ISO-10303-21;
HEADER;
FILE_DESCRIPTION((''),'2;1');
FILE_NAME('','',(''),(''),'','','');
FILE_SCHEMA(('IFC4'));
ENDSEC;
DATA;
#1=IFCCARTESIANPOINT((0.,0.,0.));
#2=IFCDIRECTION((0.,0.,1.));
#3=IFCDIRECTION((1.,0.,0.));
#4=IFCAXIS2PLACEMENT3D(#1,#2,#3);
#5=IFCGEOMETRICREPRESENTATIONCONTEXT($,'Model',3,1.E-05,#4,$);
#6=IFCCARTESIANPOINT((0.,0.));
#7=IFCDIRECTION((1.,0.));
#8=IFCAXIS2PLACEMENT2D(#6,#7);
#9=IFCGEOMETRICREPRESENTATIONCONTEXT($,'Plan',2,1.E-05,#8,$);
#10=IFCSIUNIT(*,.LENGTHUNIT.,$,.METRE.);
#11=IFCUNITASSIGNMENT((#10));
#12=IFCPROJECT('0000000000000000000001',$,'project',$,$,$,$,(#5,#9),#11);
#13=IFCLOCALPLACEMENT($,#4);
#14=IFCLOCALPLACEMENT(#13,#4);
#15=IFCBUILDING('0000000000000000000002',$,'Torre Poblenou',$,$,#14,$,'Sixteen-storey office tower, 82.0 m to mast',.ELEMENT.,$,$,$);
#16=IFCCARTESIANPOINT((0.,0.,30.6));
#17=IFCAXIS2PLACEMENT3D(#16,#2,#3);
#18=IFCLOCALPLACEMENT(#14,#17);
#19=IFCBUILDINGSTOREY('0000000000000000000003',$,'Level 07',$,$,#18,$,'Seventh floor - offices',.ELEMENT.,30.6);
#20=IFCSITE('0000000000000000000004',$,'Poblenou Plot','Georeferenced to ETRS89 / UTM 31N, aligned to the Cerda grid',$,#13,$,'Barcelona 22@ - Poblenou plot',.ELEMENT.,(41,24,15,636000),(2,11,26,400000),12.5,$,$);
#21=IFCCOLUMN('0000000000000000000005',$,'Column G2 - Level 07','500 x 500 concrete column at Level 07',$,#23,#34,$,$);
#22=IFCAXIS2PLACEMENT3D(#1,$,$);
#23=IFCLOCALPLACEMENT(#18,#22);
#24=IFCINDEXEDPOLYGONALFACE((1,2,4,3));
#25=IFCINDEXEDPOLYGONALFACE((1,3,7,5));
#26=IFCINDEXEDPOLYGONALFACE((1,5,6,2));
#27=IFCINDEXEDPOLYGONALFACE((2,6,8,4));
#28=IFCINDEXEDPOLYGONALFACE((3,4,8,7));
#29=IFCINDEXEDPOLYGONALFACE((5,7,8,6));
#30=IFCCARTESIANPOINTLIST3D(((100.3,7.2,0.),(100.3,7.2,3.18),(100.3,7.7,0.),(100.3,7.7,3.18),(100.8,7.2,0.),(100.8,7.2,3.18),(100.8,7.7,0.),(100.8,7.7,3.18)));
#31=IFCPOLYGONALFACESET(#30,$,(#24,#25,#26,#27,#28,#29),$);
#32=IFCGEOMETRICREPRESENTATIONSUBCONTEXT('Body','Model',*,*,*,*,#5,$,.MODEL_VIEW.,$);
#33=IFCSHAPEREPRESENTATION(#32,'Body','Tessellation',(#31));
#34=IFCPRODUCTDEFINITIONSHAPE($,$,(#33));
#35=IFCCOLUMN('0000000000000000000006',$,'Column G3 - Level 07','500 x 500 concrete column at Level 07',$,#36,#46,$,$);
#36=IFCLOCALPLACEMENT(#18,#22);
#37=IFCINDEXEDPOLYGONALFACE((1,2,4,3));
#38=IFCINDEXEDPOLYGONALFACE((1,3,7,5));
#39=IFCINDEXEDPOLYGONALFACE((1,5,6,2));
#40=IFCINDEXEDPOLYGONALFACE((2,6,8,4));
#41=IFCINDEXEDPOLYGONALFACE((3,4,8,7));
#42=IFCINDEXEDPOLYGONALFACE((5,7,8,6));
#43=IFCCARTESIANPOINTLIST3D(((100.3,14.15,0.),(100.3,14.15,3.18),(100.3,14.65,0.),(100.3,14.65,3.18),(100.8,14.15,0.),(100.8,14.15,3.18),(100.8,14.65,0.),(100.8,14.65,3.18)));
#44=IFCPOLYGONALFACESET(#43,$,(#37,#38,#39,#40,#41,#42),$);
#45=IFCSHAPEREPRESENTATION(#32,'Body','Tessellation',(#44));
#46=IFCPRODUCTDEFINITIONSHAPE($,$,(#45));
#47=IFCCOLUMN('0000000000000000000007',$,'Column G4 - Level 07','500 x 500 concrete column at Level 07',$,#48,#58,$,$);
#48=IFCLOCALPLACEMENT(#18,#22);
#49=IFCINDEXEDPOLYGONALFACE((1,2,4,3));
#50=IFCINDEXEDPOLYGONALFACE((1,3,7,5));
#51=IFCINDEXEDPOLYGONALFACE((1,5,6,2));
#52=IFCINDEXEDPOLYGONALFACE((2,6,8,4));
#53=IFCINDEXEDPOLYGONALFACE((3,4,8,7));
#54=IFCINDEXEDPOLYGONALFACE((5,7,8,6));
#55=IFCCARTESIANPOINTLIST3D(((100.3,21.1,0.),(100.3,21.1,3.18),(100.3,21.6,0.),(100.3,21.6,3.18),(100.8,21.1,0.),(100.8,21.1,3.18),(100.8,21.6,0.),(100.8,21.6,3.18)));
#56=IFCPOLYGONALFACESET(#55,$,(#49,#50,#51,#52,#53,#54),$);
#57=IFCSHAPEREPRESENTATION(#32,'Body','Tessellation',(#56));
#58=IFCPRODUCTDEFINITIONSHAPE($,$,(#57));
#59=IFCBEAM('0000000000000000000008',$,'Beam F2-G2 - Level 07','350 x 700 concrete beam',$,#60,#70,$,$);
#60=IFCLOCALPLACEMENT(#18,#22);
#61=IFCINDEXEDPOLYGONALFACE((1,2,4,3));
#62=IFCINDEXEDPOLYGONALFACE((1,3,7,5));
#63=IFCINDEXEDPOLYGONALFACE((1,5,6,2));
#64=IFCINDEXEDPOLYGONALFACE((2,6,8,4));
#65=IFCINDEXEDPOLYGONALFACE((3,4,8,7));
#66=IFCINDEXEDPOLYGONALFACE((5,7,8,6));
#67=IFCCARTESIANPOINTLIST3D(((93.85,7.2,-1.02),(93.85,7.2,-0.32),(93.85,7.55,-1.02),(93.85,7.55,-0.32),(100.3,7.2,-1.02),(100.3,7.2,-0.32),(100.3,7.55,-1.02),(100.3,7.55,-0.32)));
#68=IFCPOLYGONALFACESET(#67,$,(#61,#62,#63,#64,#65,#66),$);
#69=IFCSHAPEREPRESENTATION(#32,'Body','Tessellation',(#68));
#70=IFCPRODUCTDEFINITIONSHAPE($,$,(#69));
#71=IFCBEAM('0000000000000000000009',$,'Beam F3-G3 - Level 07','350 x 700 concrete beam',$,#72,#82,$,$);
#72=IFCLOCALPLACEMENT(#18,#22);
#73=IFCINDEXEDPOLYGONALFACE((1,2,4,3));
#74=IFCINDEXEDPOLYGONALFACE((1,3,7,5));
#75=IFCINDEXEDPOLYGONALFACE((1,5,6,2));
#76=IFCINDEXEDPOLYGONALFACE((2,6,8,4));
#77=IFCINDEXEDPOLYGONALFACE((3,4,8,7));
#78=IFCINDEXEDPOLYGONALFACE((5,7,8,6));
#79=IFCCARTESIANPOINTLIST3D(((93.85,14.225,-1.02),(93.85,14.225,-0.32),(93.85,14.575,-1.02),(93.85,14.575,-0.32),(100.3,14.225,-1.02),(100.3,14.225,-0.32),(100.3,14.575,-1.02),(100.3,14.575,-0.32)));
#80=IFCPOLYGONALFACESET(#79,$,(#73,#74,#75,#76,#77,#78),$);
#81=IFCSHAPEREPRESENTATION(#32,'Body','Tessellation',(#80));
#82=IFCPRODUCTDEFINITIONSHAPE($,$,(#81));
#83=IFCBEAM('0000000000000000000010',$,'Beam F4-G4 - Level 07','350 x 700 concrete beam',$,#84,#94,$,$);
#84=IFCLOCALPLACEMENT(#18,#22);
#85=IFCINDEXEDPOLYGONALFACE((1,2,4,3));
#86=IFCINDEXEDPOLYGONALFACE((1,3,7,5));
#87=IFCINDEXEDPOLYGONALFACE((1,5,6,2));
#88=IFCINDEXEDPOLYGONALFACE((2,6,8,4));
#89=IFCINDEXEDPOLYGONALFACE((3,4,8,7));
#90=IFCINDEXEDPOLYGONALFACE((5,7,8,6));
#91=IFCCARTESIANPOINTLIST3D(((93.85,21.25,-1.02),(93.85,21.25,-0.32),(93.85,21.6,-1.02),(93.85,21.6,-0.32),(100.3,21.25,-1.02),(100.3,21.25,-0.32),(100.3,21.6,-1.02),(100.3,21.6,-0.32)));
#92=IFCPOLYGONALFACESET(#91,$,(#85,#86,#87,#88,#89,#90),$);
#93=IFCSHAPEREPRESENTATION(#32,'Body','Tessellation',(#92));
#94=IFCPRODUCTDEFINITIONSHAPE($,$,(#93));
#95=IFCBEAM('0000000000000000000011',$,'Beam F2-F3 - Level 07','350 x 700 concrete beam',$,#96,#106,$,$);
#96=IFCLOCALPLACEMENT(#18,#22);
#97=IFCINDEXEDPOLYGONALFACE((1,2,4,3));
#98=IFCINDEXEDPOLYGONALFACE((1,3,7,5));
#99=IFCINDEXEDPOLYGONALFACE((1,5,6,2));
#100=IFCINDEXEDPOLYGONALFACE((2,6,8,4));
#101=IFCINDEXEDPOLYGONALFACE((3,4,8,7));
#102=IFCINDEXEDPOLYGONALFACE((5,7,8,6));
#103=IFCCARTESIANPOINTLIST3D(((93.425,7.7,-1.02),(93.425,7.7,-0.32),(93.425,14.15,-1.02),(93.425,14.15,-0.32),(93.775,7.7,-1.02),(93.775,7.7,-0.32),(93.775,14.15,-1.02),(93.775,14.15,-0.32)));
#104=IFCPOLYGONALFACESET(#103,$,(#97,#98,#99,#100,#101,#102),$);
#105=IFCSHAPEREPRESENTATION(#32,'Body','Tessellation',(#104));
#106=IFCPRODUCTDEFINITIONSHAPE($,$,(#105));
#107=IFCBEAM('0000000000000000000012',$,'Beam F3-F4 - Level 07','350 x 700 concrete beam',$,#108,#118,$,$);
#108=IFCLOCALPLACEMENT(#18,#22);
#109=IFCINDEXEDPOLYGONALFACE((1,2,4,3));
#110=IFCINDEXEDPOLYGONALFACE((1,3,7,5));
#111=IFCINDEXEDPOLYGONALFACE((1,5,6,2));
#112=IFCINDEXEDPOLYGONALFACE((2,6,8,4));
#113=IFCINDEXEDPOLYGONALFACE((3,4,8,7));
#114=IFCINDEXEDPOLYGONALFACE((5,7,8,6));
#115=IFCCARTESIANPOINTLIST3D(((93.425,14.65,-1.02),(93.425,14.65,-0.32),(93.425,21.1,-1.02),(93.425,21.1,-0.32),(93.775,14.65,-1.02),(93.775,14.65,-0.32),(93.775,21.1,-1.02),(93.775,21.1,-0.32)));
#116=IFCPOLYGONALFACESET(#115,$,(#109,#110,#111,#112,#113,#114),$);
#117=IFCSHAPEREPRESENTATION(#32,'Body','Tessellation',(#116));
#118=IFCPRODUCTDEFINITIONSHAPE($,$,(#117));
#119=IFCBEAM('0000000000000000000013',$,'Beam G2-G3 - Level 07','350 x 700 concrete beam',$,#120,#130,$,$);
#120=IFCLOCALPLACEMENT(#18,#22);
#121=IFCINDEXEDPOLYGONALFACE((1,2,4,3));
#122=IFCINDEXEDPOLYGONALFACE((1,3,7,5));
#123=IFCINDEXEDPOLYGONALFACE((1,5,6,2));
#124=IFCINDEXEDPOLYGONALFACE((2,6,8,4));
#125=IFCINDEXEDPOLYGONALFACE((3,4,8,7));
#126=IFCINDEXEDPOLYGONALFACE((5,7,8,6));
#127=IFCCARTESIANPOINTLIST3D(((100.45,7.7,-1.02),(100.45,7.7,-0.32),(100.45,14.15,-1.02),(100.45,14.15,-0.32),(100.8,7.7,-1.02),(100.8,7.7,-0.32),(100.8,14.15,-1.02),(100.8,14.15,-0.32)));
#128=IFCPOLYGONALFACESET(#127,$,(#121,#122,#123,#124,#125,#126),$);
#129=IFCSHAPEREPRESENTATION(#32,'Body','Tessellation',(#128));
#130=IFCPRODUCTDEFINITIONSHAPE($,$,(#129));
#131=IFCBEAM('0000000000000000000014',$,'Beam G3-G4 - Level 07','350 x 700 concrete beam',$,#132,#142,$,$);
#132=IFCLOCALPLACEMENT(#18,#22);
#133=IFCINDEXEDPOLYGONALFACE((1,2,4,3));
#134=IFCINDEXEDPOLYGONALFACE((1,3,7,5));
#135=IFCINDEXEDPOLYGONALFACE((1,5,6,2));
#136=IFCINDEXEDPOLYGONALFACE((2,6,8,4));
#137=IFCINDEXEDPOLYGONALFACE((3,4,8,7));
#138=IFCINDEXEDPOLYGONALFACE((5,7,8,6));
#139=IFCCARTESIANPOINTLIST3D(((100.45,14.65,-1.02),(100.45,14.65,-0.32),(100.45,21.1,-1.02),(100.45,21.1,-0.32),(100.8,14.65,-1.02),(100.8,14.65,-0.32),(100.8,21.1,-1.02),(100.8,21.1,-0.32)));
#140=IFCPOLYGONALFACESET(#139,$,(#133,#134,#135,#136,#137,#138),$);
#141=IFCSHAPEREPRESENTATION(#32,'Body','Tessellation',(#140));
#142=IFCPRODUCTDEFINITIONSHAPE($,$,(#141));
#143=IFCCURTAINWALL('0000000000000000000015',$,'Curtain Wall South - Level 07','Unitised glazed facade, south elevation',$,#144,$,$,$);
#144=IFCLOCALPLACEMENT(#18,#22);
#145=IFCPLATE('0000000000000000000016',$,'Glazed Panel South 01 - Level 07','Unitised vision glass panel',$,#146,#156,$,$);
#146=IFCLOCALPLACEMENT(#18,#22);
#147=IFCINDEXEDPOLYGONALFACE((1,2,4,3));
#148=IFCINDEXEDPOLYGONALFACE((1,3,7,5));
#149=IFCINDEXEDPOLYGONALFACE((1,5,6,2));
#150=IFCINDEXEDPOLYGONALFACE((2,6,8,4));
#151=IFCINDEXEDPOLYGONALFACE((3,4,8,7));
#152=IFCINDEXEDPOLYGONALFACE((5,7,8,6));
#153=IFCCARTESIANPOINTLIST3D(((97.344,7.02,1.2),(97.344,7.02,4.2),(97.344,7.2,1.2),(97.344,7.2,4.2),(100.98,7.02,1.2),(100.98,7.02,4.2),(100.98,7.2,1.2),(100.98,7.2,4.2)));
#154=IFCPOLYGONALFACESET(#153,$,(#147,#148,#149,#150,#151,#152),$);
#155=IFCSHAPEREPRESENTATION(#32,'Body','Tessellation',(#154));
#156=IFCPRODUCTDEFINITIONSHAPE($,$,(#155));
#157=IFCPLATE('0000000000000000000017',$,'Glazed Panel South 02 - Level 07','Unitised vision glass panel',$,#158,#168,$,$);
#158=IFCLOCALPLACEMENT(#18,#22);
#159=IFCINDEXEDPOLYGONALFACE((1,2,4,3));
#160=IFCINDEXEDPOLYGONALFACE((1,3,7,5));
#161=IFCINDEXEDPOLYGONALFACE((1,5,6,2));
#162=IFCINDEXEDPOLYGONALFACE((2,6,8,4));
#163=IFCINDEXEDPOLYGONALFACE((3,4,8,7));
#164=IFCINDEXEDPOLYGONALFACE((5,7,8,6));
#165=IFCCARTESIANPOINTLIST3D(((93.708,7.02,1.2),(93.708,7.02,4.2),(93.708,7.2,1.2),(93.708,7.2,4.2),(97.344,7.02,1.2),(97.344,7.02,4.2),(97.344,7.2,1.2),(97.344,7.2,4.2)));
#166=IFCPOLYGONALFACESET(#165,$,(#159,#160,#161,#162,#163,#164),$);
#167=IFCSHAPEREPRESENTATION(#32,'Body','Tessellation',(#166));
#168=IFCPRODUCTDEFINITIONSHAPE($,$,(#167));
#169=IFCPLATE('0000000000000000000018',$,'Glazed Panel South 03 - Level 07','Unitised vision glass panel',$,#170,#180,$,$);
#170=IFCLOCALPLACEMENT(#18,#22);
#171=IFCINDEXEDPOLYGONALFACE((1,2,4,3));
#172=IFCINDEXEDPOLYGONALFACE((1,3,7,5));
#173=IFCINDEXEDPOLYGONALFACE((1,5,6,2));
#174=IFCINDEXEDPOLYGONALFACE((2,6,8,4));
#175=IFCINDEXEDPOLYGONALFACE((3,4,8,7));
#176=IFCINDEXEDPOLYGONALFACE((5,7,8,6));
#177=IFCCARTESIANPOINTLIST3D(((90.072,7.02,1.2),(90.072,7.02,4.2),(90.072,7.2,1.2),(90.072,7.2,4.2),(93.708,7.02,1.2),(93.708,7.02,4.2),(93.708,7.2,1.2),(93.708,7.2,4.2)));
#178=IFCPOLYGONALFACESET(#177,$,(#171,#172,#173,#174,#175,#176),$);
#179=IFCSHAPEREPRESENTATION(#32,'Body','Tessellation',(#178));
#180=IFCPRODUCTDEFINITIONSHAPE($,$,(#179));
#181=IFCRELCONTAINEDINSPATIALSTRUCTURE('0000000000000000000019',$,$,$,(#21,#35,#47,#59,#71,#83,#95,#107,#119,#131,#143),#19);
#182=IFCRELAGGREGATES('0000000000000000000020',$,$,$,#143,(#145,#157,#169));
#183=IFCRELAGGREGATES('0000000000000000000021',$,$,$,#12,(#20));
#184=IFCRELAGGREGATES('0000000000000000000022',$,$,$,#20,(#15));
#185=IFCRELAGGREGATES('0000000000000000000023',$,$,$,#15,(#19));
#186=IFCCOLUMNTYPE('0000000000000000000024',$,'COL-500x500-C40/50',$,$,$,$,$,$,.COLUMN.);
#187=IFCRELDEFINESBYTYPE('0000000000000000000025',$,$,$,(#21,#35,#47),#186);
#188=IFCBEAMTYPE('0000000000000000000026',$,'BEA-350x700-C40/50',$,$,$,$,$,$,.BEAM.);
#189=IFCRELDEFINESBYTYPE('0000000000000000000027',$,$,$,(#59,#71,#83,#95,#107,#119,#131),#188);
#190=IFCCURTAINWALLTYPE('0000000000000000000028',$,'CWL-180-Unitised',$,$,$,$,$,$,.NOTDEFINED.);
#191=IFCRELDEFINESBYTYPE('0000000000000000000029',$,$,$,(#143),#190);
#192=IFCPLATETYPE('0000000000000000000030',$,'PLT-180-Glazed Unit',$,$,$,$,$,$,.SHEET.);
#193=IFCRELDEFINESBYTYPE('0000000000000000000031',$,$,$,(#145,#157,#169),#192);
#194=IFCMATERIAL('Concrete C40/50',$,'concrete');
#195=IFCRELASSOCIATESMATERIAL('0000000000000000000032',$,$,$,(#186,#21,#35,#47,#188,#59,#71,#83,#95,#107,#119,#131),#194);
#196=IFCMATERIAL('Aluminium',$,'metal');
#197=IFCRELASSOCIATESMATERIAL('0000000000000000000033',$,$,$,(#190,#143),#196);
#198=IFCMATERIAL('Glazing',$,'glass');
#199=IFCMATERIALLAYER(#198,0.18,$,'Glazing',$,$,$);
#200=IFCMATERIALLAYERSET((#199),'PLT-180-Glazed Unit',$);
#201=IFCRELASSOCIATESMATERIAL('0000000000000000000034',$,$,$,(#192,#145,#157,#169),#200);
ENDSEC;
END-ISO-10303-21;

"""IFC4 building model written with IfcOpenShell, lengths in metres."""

from ifc_helpers import new_model, si_unit, frame, origin_with_axes, origin_2d_with_axis, place, context, subcontext, project, spatial, line, indexed_curve, rectangle, outline, extrude, material, layer, layer_set, layer_usage, material_profile, profile_set, profile_usage, type_object, element, aggregate, save


model = new_model("IFC4")

# Units and contexts
model_context = context("Model", 3, precision=1e-05, world=origin_with_axes())
plan_context = context("Plan", 2, precision=1e-05, world=origin_2d_with_axis())
body_context = subcontext(model_context, "Body", "Model", "MODEL_VIEW")
ifc_project = project(units=[si_unit("LENGTHUNIT", "METRE")], contexts=[model_context, plan_context])

# Site, building, storey
site_placement = place(None, origin_with_axes())
site = spatial("IfcSite", under=ifc_project, at=site_placement, Name="Poblenou Plot", Description="Georeferenced to ETRS89 / UTM 31N, aligned to the Cerda grid", LongName="Barcelona 22@ - Poblenou plot", CompositionType="ELEMENT", RefLatitude=(41, 24, 15, 636000), RefLongitude=(2, 11, 26, 400000), RefElevation=12.5)
building_placement = place(site_placement, origin_with_axes())
building = spatial("IfcBuilding", under=site, at=building_placement, Name="Torre Poblenou", LongName="Sixteen-storey office tower, 82.0 m to mast", CompositionType="ELEMENT")
storey_placement = place(building_placement, frame((0.0, 0.0, 30.6), z_axis=(0.0, 0.0, 1.0), x_axis=(1.0, 0.0, 0.0)))
storey = spatial("IfcBuildingStorey", under=building, at=storey_placement, Name="Level 07", LongName="Seventh floor - offices", CompositionType="ELEMENT", Elevation=30.6)

# Columns
ifc_material_1 = material(Name="Concrete C40/50", Category="concrete")
ifc_material_profile_1 = material_profile(ifc_material_1, rectangle(XDim=0.5, YDim=0.5))
ifc_profile_set_1 = profile_set([ifc_material_profile_1], Name="COL-500x500-C40/50")
ifc_profile_usage_1 = profile_usage(ifc_profile_set_1)
column_type = type_object("IfcColumnType", Name="COL-500x500-C40/50", PredefinedType="COLUMN", material=ifc_profile_set_1)
column_1_placement = place(storey_placement, frame((100.3, 7.2, 0.0), z_axis=(0.0, 0.0, 1.0), x_axis=(1.0, 0.0, 0.0)))
element("IfcColumn", 1, at=column_1_placement, inside=storey, type_object=column_type, material=ifc_profile_usage_1, Name="Column G2 - Level 07", Description="500 x 500 concrete column at Level 07", context=body_context, shape_type="SweptSolid", body=[
    extrude(outline(indexed_curve([(0.0, 0.0), (0.5, 0.0), (0.5, 0.5), (0.0, 0.5)], segments=[line(1, 2, 3, 4, 1)])), origin_with_axes(), (0.0, 0.0, 1.0), 3.18),
])
ifc_profile_usage_2 = profile_usage(ifc_profile_set_1)
column_2_placement = place(storey_placement, frame((100.3, 14.15, 0.0), z_axis=(0.0, 0.0, 1.0), x_axis=(1.0, 0.0, 0.0)))
element("IfcColumn", 2, at=column_2_placement, inside=storey, type_object=column_type, material=ifc_profile_usage_2, Name="Column G3 - Level 07", Description="500 x 500 concrete column at Level 07", context=body_context, shape_type="SweptSolid", body=[
    extrude(outline(indexed_curve([(0.0, 0.0), (0.5, 0.0), (0.5, 0.5), (0.0, 0.5)], segments=[line(1, 2, 3, 4, 1)])), origin_with_axes(), (0.0, 0.0, 1.0), 3.18),
])
ifc_profile_usage_3 = profile_usage(ifc_profile_set_1)
column_3_placement = place(storey_placement, frame((100.3, 21.1, 0.0), z_axis=(0.0, 0.0, 1.0), x_axis=(1.0, 0.0, 0.0)))
element("IfcColumn", 3, at=column_3_placement, inside=storey, type_object=column_type, material=ifc_profile_usage_3, Name="Column G4 - Level 07", Description="500 x 500 concrete column at Level 07", context=body_context, shape_type="SweptSolid", body=[
    extrude(outline(indexed_curve([(0.0, 0.0), (0.5, 0.0), (0.5, 0.5), (0.0, 0.5)], segments=[line(1, 2, 3, 4, 1)])), origin_with_axes(), (0.0, 0.0, 1.0), 3.18),
])

# Beams
ifc_material_profile_2 = material_profile(ifc_material_1, rectangle(XDim=0.35, YDim=0.7))
ifc_profile_set_2 = profile_set([ifc_material_profile_2], Name="BEA-350x700-C40/50")
ifc_profile_usage_4 = profile_usage(ifc_profile_set_2)
beam_type = type_object("IfcBeamType", Name="BEA-350x700-C40/50", PredefinedType="BEAM", material=ifc_profile_set_2)
beam_1_placement = place(storey_placement, frame((93.85, 7.2, -1.02), z_axis=(0.0, 0.0, 1.0), x_axis=(1.0, 0.0, 0.0)))
element("IfcBeam", 4, at=beam_1_placement, inside=storey, type_object=beam_type, material=ifc_profile_usage_4, Name="Beam F2-G2 - Level 07", Description="350 x 700 concrete beam", context=body_context, shape_type="SweptSolid", body=[
    extrude(outline(indexed_curve([(0.0, 0.0), (6.45, 0.0), (6.45, 0.35), (0.0, 0.35)], segments=[line(1, 2, 3, 4, 1)])), origin_with_axes(), (0.0, 0.0, 1.0), 0.7),
])
ifc_profile_usage_5 = profile_usage(ifc_profile_set_2)
beam_2_placement = place(storey_placement, frame((93.85, 14.225, -1.02), z_axis=(0.0, 0.0, 1.0), x_axis=(1.0, 0.0, 0.0)))
element("IfcBeam", 5, at=beam_2_placement, inside=storey, type_object=beam_type, material=ifc_profile_usage_5, Name="Beam F3-G3 - Level 07", Description="350 x 700 concrete beam", context=body_context, shape_type="SweptSolid", body=[
    extrude(outline(indexed_curve([(0.0, 0.0), (6.45, 0.0), (6.45, 0.35), (0.0, 0.35)], segments=[line(1, 2, 3, 4, 1)])), origin_with_axes(), (0.0, 0.0, 1.0), 0.7),
])
ifc_profile_usage_6 = profile_usage(ifc_profile_set_2)
beam_3_placement = place(storey_placement, frame((93.85, 21.25, -1.02), z_axis=(0.0, 0.0, 1.0), x_axis=(1.0, 0.0, 0.0)))
element("IfcBeam", 6, at=beam_3_placement, inside=storey, type_object=beam_type, material=ifc_profile_usage_6, Name="Beam F4-G4 - Level 07", Description="350 x 700 concrete beam", context=body_context, shape_type="SweptSolid", body=[
    extrude(outline(indexed_curve([(0.0, 0.0), (6.45, 0.0), (6.45, 0.35), (0.0, 0.35)], segments=[line(1, 2, 3, 4, 1)])), origin_with_axes(), (0.0, 0.0, 1.0), 0.7),
])
ifc_profile_usage_7 = profile_usage(ifc_profile_set_2)
beam_4_placement = place(storey_placement, frame((93.775, 7.7, -1.02), z_axis=(0.0, 0.0, 1.0), x_axis=(0.0, 1.0, 0.0)))
element("IfcBeam", 7, at=beam_4_placement, inside=storey, type_object=beam_type, material=ifc_profile_usage_7, Name="Beam F2-F3 - Level 07", Description="350 x 700 concrete beam", context=body_context, shape_type="SweptSolid", body=[
    extrude(outline(indexed_curve([(0.0, 0.0), (6.45, 0.0), (6.45, 0.35), (0.0, 0.35)], segments=[line(1, 2, 3, 4, 1)])), origin_with_axes(), (0.0, 0.0, 1.0), 0.7),
])
ifc_profile_usage_8 = profile_usage(ifc_profile_set_2)
beam_5_placement = place(storey_placement, frame((93.775, 14.65, -1.02), z_axis=(0.0, 0.0, 1.0), x_axis=(0.0, 1.0, 0.0)))
element("IfcBeam", 8, at=beam_5_placement, inside=storey, type_object=beam_type, material=ifc_profile_usage_8, Name="Beam F3-F4 - Level 07", Description="350 x 700 concrete beam", context=body_context, shape_type="SweptSolid", body=[
    extrude(outline(indexed_curve([(0.0, 0.0), (6.45, 0.0), (6.45, 0.35), (0.0, 0.35)], segments=[line(1, 2, 3, 4, 1)])), origin_with_axes(), (0.0, 0.0, 1.0), 0.7),
])
ifc_profile_usage_9 = profile_usage(ifc_profile_set_2)
beam_6_placement = place(storey_placement, frame((100.8, 7.7, -1.02), z_axis=(0.0, 0.0, 1.0), x_axis=(0.0, 1.0, 0.0)))
element("IfcBeam", 9, at=beam_6_placement, inside=storey, type_object=beam_type, material=ifc_profile_usage_9, Name="Beam G2-G3 - Level 07", Description="350 x 700 concrete beam", context=body_context, shape_type="SweptSolid", body=[
    extrude(outline(indexed_curve([(0.0, 0.0), (6.45, 0.0), (6.45, 0.35), (0.0, 0.35)], segments=[line(1, 2, 3, 4, 1)])), origin_with_axes(), (0.0, 0.0, 1.0), 0.7),
])
ifc_profile_usage_10 = profile_usage(ifc_profile_set_2)
beam_7_placement = place(storey_placement, frame((100.8, 14.65, -1.02), z_axis=(0.0, 0.0, 1.0), x_axis=(0.0, 1.0, 0.0)))
element("IfcBeam", 10, at=beam_7_placement, inside=storey, type_object=beam_type, material=ifc_profile_usage_10, Name="Beam G3-G4 - Level 07", Description="350 x 700 concrete beam", context=body_context, shape_type="SweptSolid", body=[
    extrude(outline(indexed_curve([(0.0, 0.0), (6.45, 0.0), (6.45, 0.35), (0.0, 0.35)], segments=[line(1, 2, 3, 4, 1)])), origin_with_axes(), (0.0, 0.0, 1.0), 0.7),
])

# Curtain wall, plates
ifc_material_2 = material(Name="Aluminium", Category="metal")
curtain_wall_type = type_object("IfcCurtainWallType", Name="CWL-180-Unitised", PredefinedType="NOTDEFINED", material=ifc_material_2)
curtain_wall_1_placement = place(storey_placement, frame((100.98, 7.2, 0.0), z_axis=(0.0, 0.0, 1.0), x_axis=(-1.0, 0.0, 0.0)))
curtain_wall_1 = element("IfcCurtainWall", 11, at=curtain_wall_1_placement, inside=storey, type_object=curtain_wall_type, material=ifc_material_2, Name="Curtain Wall South - Level 07", Description="Unitised glazed facade, south elevation")
ifc_material_3 = material(Name="Glazing", Category="glass")
ifc_layer_1 = layer(ifc_material_3, 0.18, Name="Glazing")
ifc_layer_set_1 = layer_set([ifc_layer_1], Name="PLT-180-Glazed Unit")
ifc_layer_usage_1 = layer_usage(ifc_layer_set_1, "AXIS2", "POSITIVE", 0.0)
plate_type_1 = type_object("IfcPlateType", Name="PLT-180-Glazed Unit", PredefinedType="SHEET", material=ifc_layer_set_1)
plate_1_placement = place(curtain_wall_1_placement, frame((0.0, 0.0, 1.2), z_axis=(0.0, 0.0, 1.0), x_axis=(1.0, 0.0, 0.0)))
plate_1 = element("IfcPlate", 12, at=plate_1_placement, type_object=plate_type_1, material=ifc_layer_usage_1, Name="Glazed Panel South 01 - Level 07", Description="Unitised vision glass panel", context=body_context, shape_type="SweptSolid", body=[
    extrude(outline(indexed_curve([(0.0, 0.0), (3.636, 0.0), (3.636, 0.18), (0.0, 0.18)], segments=[line(1, 2, 3, 4, 1)])), origin_with_axes(), (0.0, 0.0, 1.0), 3.0),
])
ifc_layer_usage_2 = layer_usage(ifc_layer_set_1, "AXIS2", "POSITIVE", 0.0)
plate_2_placement = place(curtain_wall_1_placement, frame((3.636, 0.0, 1.2), z_axis=(0.0, 0.0, 1.0), x_axis=(1.0, 0.0, 0.0)))
plate_2 = element("IfcPlate", 13, at=plate_2_placement, type_object=plate_type_1, material=ifc_layer_usage_2, Name="Glazed Panel South 02 - Level 07", Description="Unitised vision glass panel", context=body_context, shape_type="SweptSolid", body=[
    extrude(outline(indexed_curve([(0.0, 0.0), (3.636, 0.0), (3.636, 0.18), (0.0, 0.18)], segments=[line(1, 2, 3, 4, 1)])), origin_with_axes(), (0.0, 0.0, 1.0), 3.0),
])
ifc_layer_usage_3 = layer_usage(ifc_layer_set_1, "AXIS2", "POSITIVE", 0.0)
plate_3_placement = place(curtain_wall_1_placement, frame((7.272, 0.0, 1.2), z_axis=(0.0, 0.0, 1.0), x_axis=(1.0, 0.0, 0.0)))
plate_3 = element("IfcPlate", 14, at=plate_3_placement, type_object=plate_type_1, material=ifc_layer_usage_3, Name="Glazed Panel South 03 - Level 07", Description="Unitised vision glass panel", context=body_context, shape_type="SweptSolid", body=[
    extrude(outline(indexed_curve([(0.0, 0.0), (3.636, 0.0), (3.636, 0.18), (0.0, 0.18)], segments=[line(1, 2, 3, 4, 1)])), origin_with_axes(), (0.0, 0.0, 1.0), 3.0),
])

aggregate(curtain_wall_1, [plate_1, plate_2, plate_3])

save(model, "model.ifc")
